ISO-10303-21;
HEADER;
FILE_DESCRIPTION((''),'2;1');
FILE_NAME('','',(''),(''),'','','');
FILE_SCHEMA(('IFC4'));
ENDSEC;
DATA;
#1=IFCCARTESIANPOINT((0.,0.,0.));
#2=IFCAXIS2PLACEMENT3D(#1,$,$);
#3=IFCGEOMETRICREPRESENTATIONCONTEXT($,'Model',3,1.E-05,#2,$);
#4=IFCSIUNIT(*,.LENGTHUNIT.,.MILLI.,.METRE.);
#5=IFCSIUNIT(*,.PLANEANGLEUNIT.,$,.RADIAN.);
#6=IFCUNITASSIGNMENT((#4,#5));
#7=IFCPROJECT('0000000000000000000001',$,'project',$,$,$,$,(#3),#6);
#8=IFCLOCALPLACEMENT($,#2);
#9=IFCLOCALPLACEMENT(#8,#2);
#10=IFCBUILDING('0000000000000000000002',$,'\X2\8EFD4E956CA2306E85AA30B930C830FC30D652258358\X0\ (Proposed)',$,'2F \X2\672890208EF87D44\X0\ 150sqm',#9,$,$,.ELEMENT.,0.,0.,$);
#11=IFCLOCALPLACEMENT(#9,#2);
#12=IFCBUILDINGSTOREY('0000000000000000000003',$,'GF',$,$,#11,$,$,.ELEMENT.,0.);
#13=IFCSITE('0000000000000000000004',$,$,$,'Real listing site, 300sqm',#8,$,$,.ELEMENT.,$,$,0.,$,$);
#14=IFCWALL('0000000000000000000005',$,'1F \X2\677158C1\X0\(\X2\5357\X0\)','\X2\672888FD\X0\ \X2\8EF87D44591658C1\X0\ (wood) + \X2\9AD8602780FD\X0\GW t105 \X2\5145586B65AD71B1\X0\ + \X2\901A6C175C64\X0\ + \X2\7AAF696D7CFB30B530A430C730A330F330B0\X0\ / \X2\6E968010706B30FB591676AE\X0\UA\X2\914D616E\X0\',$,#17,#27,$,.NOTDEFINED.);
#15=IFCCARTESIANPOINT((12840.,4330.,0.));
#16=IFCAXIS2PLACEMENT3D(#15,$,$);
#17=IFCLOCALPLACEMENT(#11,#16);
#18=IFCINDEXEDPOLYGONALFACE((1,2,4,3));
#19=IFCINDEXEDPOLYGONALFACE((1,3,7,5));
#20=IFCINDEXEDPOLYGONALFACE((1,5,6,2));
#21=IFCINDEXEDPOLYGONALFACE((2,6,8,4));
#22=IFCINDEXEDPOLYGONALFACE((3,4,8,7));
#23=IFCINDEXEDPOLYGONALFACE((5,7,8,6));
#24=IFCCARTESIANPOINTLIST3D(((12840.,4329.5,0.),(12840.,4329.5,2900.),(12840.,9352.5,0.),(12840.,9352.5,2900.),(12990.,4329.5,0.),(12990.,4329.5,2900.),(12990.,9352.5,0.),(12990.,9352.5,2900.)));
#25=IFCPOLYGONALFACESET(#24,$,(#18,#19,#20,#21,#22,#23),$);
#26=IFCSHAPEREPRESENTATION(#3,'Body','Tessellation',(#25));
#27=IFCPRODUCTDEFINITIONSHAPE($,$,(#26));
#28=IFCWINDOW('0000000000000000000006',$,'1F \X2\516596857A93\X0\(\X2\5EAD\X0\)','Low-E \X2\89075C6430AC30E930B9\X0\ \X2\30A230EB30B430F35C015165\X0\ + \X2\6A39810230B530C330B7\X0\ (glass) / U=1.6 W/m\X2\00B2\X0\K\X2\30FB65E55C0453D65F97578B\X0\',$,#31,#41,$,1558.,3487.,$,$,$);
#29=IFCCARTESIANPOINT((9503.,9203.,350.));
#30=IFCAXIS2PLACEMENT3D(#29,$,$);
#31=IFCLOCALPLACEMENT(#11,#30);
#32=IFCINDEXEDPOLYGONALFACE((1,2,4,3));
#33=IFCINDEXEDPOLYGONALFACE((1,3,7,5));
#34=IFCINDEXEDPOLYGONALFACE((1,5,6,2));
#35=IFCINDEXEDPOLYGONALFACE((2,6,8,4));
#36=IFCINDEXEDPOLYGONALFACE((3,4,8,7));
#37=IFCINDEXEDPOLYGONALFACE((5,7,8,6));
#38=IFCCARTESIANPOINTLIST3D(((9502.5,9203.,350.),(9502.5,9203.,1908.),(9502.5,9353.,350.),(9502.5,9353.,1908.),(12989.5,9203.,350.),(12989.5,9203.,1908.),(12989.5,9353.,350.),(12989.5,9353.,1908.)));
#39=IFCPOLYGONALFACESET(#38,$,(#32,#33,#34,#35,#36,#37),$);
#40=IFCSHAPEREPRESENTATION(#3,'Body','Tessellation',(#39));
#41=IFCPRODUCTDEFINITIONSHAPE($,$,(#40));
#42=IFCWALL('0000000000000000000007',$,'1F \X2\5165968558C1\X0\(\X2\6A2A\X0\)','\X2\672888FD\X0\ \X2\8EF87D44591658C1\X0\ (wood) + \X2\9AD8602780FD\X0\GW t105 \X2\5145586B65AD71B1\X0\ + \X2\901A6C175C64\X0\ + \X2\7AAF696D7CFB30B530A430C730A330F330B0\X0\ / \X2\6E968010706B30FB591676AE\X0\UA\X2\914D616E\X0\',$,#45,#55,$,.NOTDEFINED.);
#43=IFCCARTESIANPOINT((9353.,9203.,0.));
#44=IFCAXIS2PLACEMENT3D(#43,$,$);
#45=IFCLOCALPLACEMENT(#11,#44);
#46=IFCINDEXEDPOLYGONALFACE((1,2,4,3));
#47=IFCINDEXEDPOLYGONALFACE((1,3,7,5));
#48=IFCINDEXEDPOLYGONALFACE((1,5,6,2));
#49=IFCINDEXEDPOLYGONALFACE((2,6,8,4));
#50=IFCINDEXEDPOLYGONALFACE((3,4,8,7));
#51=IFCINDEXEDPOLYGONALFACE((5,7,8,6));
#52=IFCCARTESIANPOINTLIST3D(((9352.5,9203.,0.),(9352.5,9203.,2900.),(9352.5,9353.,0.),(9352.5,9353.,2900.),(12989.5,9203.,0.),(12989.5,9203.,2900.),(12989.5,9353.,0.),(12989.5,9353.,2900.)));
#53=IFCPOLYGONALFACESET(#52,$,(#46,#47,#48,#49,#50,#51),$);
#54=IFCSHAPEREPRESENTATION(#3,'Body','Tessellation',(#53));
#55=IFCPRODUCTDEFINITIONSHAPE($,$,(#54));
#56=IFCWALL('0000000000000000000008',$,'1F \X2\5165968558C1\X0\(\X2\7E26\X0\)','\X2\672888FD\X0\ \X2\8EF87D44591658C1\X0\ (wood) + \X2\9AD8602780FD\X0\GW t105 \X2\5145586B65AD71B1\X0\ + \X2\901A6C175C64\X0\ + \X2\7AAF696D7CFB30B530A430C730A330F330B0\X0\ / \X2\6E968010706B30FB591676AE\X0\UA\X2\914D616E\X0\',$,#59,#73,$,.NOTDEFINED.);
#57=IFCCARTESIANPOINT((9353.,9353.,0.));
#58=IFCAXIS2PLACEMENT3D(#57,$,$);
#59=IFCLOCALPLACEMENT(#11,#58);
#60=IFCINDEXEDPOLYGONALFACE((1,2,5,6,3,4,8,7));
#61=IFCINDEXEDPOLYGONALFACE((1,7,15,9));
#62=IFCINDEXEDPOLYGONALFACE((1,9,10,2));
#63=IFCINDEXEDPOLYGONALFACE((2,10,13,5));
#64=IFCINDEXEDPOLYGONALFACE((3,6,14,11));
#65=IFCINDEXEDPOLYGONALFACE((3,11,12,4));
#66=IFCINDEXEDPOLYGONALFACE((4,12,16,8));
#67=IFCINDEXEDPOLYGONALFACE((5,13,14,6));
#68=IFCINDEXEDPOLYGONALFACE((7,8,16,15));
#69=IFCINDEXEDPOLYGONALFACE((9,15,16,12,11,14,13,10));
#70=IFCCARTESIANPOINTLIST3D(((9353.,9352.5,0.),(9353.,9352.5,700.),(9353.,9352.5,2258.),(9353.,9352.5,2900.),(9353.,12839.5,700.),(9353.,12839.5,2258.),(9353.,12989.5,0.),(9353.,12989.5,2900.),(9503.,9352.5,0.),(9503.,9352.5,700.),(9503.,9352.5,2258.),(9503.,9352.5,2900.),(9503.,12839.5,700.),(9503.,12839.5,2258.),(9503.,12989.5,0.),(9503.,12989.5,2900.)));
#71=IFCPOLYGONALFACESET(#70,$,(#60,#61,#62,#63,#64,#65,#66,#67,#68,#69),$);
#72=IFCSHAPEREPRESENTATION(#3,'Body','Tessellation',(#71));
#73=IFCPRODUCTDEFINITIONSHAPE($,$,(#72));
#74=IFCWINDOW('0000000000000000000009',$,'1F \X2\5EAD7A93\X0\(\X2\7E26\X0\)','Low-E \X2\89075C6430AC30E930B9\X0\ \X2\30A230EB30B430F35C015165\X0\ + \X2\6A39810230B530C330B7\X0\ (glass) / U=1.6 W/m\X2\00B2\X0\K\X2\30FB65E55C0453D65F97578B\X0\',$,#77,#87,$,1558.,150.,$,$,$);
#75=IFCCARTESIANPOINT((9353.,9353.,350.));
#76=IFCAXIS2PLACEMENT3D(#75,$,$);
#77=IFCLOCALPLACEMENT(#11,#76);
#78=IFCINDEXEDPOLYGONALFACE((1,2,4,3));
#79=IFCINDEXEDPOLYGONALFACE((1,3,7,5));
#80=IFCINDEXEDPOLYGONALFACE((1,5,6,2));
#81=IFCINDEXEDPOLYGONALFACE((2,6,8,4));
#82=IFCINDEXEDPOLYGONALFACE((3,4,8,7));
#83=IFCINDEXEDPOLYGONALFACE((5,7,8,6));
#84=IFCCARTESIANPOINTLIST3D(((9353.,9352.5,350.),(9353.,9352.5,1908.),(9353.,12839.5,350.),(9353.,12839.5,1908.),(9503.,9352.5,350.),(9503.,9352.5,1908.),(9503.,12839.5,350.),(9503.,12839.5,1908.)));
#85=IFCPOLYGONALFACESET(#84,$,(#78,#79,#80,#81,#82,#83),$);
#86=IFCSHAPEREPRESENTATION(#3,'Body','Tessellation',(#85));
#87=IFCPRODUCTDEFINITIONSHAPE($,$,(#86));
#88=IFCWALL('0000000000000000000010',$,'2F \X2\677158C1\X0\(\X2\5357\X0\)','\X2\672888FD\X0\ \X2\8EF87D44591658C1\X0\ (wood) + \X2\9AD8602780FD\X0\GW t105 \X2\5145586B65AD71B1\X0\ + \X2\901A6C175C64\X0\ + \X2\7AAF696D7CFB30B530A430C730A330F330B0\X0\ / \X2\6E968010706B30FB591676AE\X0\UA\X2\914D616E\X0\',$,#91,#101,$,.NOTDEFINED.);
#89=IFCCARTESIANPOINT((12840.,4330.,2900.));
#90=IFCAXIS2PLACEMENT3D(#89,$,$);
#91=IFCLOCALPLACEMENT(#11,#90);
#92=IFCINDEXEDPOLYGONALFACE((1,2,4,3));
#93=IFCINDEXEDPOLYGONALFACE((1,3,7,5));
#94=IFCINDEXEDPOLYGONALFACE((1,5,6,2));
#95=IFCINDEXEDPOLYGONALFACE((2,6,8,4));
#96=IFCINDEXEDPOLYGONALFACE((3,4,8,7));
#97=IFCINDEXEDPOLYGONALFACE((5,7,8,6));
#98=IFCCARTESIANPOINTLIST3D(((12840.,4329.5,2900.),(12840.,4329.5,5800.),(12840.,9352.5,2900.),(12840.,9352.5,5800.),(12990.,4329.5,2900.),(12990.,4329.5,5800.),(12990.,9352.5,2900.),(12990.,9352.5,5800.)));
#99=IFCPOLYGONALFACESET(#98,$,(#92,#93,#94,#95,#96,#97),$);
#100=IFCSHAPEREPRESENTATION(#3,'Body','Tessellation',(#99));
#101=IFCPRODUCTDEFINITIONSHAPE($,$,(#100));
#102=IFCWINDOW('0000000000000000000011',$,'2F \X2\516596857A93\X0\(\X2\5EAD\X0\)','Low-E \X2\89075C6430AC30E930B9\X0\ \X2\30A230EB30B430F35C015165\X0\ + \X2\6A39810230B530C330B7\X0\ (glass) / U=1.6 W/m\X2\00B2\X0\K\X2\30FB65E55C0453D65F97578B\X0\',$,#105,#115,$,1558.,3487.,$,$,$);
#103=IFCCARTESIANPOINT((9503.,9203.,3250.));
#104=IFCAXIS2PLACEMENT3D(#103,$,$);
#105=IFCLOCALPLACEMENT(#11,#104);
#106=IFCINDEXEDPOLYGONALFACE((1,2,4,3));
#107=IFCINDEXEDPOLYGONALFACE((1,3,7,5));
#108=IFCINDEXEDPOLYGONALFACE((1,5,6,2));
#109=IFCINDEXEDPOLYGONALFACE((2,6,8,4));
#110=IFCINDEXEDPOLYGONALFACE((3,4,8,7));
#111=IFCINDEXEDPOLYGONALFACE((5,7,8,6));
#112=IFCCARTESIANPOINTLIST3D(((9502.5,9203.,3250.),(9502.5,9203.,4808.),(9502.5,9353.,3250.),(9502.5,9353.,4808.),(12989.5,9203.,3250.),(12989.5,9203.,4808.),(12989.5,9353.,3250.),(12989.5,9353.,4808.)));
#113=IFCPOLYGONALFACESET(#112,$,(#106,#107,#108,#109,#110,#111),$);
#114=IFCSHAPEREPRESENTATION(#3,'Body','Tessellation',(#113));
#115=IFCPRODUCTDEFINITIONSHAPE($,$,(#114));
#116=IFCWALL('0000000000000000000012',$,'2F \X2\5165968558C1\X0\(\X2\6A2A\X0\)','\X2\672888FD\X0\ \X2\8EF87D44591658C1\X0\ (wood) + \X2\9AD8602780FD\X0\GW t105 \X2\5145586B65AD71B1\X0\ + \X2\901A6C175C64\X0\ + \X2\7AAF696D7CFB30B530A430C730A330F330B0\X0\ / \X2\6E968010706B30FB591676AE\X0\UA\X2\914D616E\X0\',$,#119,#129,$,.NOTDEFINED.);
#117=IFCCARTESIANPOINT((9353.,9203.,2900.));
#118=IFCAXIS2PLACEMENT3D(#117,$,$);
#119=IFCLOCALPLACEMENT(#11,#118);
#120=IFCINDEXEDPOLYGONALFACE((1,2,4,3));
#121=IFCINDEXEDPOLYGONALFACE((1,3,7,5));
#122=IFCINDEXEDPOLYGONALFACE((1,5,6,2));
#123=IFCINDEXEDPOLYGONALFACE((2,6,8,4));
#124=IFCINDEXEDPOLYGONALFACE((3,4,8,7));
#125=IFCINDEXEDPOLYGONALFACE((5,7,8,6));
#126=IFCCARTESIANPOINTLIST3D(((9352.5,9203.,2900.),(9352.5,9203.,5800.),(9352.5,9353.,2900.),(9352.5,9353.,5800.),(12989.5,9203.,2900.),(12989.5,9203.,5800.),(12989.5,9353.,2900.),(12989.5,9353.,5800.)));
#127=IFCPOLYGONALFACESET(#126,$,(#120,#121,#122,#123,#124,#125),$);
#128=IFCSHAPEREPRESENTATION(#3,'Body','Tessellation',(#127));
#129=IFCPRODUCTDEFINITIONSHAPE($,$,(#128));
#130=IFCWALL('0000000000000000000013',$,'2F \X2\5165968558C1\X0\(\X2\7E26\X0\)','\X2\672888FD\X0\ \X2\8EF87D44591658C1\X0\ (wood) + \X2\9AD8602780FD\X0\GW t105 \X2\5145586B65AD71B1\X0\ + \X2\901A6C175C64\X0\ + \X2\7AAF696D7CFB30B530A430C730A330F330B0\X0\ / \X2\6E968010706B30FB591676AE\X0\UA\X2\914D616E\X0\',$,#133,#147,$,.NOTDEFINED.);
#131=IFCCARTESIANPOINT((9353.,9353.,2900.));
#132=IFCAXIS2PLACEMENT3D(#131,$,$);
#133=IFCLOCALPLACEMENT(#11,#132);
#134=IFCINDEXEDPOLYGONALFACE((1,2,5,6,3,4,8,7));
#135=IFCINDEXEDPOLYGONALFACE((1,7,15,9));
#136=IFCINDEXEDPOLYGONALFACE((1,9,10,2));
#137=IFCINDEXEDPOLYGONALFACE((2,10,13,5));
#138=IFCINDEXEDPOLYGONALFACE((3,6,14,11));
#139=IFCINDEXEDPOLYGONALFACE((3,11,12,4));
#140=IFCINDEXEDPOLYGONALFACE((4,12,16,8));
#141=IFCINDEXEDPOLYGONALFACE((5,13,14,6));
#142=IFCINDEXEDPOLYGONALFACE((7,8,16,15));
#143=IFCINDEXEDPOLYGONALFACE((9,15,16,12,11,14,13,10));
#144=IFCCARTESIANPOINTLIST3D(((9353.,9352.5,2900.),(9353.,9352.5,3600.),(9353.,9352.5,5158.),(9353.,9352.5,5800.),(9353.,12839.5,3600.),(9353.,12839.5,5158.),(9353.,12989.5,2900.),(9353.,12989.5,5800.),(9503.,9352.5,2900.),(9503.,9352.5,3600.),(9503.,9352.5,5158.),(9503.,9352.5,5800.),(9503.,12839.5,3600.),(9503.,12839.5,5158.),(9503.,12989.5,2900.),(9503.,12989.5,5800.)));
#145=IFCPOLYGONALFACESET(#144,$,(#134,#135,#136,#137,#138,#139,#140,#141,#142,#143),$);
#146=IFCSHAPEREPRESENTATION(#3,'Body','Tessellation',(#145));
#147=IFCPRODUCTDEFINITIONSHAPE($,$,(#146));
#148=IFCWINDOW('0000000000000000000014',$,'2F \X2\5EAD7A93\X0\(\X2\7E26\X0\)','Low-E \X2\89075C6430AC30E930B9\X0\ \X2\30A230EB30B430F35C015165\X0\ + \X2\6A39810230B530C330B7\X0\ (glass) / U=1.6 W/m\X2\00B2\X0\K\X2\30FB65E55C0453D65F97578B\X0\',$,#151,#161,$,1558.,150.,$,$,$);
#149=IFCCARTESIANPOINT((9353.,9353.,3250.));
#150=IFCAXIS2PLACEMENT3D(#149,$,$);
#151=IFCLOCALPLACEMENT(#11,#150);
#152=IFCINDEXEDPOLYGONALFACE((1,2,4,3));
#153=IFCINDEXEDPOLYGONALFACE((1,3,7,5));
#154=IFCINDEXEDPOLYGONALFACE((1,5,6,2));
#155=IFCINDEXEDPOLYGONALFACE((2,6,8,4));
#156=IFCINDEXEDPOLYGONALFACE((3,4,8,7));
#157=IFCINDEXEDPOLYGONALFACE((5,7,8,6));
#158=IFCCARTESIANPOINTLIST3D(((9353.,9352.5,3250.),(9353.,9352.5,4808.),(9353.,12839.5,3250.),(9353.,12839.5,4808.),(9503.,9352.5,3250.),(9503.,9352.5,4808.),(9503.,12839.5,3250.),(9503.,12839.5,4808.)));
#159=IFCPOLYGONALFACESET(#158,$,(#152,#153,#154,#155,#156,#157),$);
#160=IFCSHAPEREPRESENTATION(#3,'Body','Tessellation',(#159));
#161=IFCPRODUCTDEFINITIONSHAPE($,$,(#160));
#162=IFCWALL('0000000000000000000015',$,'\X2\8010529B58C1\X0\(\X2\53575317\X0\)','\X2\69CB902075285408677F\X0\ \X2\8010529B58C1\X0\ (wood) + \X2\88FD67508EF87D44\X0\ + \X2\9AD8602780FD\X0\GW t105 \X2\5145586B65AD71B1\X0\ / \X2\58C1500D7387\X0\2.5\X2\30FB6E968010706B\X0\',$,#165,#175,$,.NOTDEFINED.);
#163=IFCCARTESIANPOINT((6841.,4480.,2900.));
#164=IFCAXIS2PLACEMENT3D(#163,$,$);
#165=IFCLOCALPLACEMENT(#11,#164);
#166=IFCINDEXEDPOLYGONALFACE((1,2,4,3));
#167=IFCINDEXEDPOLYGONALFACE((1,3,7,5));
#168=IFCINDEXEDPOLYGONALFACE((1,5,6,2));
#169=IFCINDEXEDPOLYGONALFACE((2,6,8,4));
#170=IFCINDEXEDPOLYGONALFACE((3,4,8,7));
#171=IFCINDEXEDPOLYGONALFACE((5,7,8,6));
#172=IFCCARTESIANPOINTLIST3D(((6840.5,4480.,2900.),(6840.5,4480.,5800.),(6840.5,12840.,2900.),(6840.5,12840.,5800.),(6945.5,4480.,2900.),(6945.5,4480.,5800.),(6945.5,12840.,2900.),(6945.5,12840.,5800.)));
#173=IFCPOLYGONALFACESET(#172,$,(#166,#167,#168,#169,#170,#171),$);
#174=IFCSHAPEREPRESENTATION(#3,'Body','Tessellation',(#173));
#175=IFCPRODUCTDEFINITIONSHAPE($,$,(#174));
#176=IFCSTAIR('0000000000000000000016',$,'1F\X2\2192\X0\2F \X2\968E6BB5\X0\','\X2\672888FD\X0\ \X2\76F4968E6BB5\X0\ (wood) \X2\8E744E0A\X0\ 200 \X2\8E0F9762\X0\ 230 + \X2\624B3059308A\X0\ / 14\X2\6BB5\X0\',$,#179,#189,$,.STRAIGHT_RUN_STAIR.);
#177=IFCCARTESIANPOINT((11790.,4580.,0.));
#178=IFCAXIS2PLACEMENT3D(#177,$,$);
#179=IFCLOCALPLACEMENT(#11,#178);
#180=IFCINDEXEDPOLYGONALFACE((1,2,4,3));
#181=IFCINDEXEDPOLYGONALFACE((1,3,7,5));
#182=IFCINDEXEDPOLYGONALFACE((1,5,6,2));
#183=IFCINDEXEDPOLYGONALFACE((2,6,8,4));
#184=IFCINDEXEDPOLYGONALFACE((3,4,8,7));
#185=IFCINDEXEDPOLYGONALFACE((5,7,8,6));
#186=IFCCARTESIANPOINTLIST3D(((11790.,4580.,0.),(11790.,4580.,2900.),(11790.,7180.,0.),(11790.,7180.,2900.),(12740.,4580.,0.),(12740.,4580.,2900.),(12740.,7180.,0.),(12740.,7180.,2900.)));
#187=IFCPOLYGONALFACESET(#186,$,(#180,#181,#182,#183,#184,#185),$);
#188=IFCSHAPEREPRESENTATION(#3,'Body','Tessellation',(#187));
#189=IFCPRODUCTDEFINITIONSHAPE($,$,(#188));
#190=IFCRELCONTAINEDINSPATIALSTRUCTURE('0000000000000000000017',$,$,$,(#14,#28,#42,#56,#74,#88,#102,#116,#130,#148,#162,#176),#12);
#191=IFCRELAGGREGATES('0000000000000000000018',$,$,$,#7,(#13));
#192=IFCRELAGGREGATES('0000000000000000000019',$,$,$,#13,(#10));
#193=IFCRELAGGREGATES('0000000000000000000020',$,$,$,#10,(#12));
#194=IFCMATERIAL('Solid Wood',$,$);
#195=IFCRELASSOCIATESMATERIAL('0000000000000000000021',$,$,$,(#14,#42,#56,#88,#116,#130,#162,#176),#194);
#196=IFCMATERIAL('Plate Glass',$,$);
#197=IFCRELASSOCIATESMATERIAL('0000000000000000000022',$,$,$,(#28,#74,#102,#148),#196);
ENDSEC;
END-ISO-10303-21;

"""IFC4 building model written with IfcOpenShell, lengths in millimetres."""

from ifc_helpers import new_model, si_unit, frame, frame_2d, origin, place, context, project, spatial, rectangle, extrude, material, element, fill, save


model = new_model("IFC4")

# Units and contexts
model_context = context("Model", 3, precision=1e-05, world=origin())
ifc_project = project(units=[si_unit("LENGTHUNIT", "METRE", prefix="MILLI"), si_unit("PLANEANGLEUNIT", "RADIAN")], contexts=[model_context])

# Site, building, storey
site_placement = place(None, origin())
site = spatial("IfcSite", under=ifc_project, at=site_placement, ObjectType="Real listing site, 300sqm", CompositionType="ELEMENT", RefElevation=0.0)
building_placement = place(site_placement, origin())
building = spatial("IfcBuilding", under=site, at=building_placement, Name="軽井沢の薪ストーブ別荘 (Proposed)", ObjectType="2F 木造軸組 150sqm", CompositionType="ELEMENT", ElevationOfRefHeight=0.0, ElevationOfTerrain=0.0)
storey_placement = place(building_placement, origin())
storey = spatial("IfcBuildingStorey", under=building, at=storey_placement, Name="GF", CompositionType="ELEMENT", Elevation=0.0)

# Shared definitions
ifc_material_1 = material(Name="Solid Wood")

# Wall, opening, window
wall_1_placement = place(storey_placement, frame((12840.0, 4330.0, 0.0)))
wall_1 = element("IfcWall", 1, at=wall_1_placement, inside=storey, material=ifc_material_1, Name="1F 東壁(南)", Description="木製 軸組外壁 (wood) + 高性能GW t105 充填断熱 + 通気層 + 窯業系サイディング / 準耐火・外皮UA配慮", PredefinedType="NOTDEFINED", context=model_context, shape_type="SweptSolid", body=[
    extrude(rectangle(XDim=150.0, YDim=5023.0, at=frame_2d((75.0, 2511.0))), frame((12840.0, 4330.0, 0.0)), (0.0, 0.0, 1.0), 2900.0),
])
opening_1_placement = place(storey_placement, frame((9503.0, 9203.0, 350.0)))
opening_1 = element("IfcOpeningElement", 2, at=opening_1_placement, cuts=wall_1, PredefinedType="NOTDEFINED", context=model_context, shape_type="SweptSolid", body=[
    extrude(rectangle(XDim=3487.0, YDim=150.0, at=frame_2d((1743.0, 75.0))), frame((9503.0, 9203.0, 350.0)), (0.0, 0.0, 1.0), 1558.0),
])
ifc_material_2 = material(Name="Plate Glass")
window_1_placement = place(storey_placement, frame((9503.0, 9203.0, 350.0)))
window_1 = element("IfcWindow", 3, at=window_1_placement, inside=storey, material=ifc_material_2, Name="1F 入隅窓(庭)", Description="Low-E 複層ガラス アルゴン封入 + 樹脂サッシ (glass) / U=1.6 W/m²K・日射取得型", OverallHeight=1558.0, OverallWidth=3487.0, context=model_context, shape_type="SweptSolid", body=[
    extrude(rectangle(XDim=3487.0, YDim=150.0, at=frame_2d((1743.0, 75.0))), frame((9503.0, 9203.0, 350.0)), (0.0, 0.0, 1.0), 1558.0),
])
fill(opening_1, window_1)

# Wall
wall_2_placement = place(storey_placement, frame((9353.0, 9203.0, 0.0)))
element("IfcWall", 4, at=wall_2_placement, inside=storey, material=ifc_material_1, Name="1F 入隅壁(横)", Description="木製 軸組外壁 (wood) + 高性能GW t105 充填断熱 + 通気層 + 窯業系サイディング / 準耐火・外皮UA配慮", PredefinedType="NOTDEFINED", context=model_context, shape_type="SweptSolid", body=[
    extrude(rectangle(XDim=3637.0, YDim=150.0, at=frame_2d((1818.0, 75.0))), frame((9353.0, 9203.0, 0.0)), (0.0, 0.0, 1.0), 2900.0),
])

# Wall, opening, window
wall_3_placement = place(storey_placement, frame((9353.0, 9353.0, 0.0)))
wall_3 = element("IfcWall", 5, at=wall_3_placement, inside=storey, material=ifc_material_1, Name="1F 入隅壁(縦)", Description="木製 軸組外壁 (wood) + 高性能GW t105 充填断熱 + 通気層 + 窯業系サイディング / 準耐火・外皮UA配慮", PredefinedType="NOTDEFINED", context=model_context, shape_type="SweptSolid", body=[
    extrude(rectangle(XDim=150.0, YDim=3637.0, at=frame_2d((75.0, 1818.0))), frame((9353.0, 9353.0, 0.0)), (0.0, 0.0, 1.0), 2900.0),
])
opening_2_placement = place(storey_placement, frame((9353.0, 9353.0, 350.0)))
opening_2 = element("IfcOpeningElement", 6, at=opening_2_placement, cuts=wall_3, PredefinedType="NOTDEFINED", context=model_context, shape_type="SweptSolid", body=[
    extrude(rectangle(XDim=150.0, YDim=3487.0, at=frame_2d((75.0, 1743.0))), frame((9353.0, 9353.0, 350.0)), (0.0, 0.0, 1.0), 1558.0),
])
window_2_placement = place(storey_placement, frame((9353.0, 9353.0, 350.0)))
window_2 = element("IfcWindow", 7, at=window_2_placement, inside=storey, material=ifc_material_2, Name="1F 庭窓(縦)", Description="Low-E 複層ガラス アルゴン封入 + 樹脂サッシ (glass) / U=1.6 W/m²K・日射取得型", OverallHeight=1558.0, OverallWidth=150.0, context=model_context, shape_type="SweptSolid", body=[
    extrude(rectangle(XDim=150.0, YDim=3487.0, at=frame_2d((75.0, 1743.0))), frame((9353.0, 9353.0, 350.0)), (0.0, 0.0, 1.0), 1558.0),
])
fill(opening_2, window_2)

# Wall, opening, window
wall_4_placement = place(storey_placement, frame((12840.0, 4330.0, 2900.0)))
wall_4 = element("IfcWall", 8, at=wall_4_placement, inside=storey, material=ifc_material_1, Name="2F 東壁(南)", Description="木製 軸組外壁 (wood) + 高性能GW t105 充填断熱 + 通気層 + 窯業系サイディング / 準耐火・外皮UA配慮", PredefinedType="NOTDEFINED", context=model_context, shape_type="SweptSolid", body=[
    extrude(rectangle(XDim=150.0, YDim=5023.0, at=frame_2d((75.0, 2511.0))), frame((12840.0, 4330.0, 2900.0)), (0.0, 0.0, 1.0), 2900.0),
])
opening_3_placement = place(storey_placement, frame((9503.0, 9203.0, 3250.0)))
opening_3 = element("IfcOpeningElement", 9, at=opening_3_placement, cuts=wall_4, PredefinedType="NOTDEFINED", context=model_context, shape_type="SweptSolid", body=[
    extrude(rectangle(XDim=3487.0, YDim=150.0, at=frame_2d((1743.0, 75.0))), frame((9503.0, 9203.0, 3250.0)), (0.0, 0.0, 1.0), 1558.0),
])
window_3_placement = place(storey_placement, frame((9503.0, 9203.0, 3250.0)))
window_3 = element("IfcWindow", 10, at=window_3_placement, inside=storey, material=ifc_material_2, Name="2F 入隅窓(庭)", Description="Low-E 複層ガラス アルゴン封入 + 樹脂サッシ (glass) / U=1.6 W/m²K・日射取得型", OverallHeight=1558.0, OverallWidth=3487.0, context=model_context, shape_type="SweptSolid", body=[
    extrude(rectangle(XDim=3487.0, YDim=150.0, at=frame_2d((1743.0, 75.0))), frame((9503.0, 9203.0, 3250.0)), (0.0, 0.0, 1.0), 1558.0),
])
fill(opening_3, window_3)

# Wall
wall_5_placement = place(storey_placement, frame((9353.0, 9203.0, 2900.0)))
element("IfcWall", 11, at=wall_5_placement, inside=storey, material=ifc_material_1, Name="2F 入隅壁(横)", Description="木製 軸組外壁 (wood) + 高性能GW t105 充填断熱 + 通気層 + 窯業系サイディング / 準耐火・外皮UA配慮", PredefinedType="NOTDEFINED", context=model_context, shape_type="SweptSolid", body=[
    extrude(rectangle(XDim=3637.0, YDim=150.0, at=frame_2d((1818.0, 75.0))), frame((9353.0, 9203.0, 2900.0)), (0.0, 0.0, 1.0), 2900.0),
])

# Wall, opening, window
wall_6_placement = place(storey_placement, frame((9353.0, 9353.0, 2900.0)))
wall_6 = element("IfcWall", 12, at=wall_6_placement, inside=storey, material=ifc_material_1, Name="2F 入隅壁(縦)", Description="木製 軸組外壁 (wood) + 高性能GW t105 充填断熱 + 通気層 + 窯業系サイディング / 準耐火・外皮UA配慮", PredefinedType="NOTDEFINED", context=model_context, shape_type="SweptSolid", body=[
    extrude(rectangle(XDim=150.0, YDim=3637.0, at=frame_2d((75.0, 1818.0))), frame((9353.0, 9353.0, 2900.0)), (0.0, 0.0, 1.0), 2900.0),
])
opening_4_placement = place(storey_placement, frame((9353.0, 9353.0, 3250.0)))
opening_4 = element("IfcOpeningElement", 13, at=opening_4_placement, cuts=wall_6, PredefinedType="NOTDEFINED", context=model_context, shape_type="SweptSolid", body=[
    extrude(rectangle(XDim=150.0, YDim=3487.0, at=frame_2d((75.0, 1743.0))), frame((9353.0, 9353.0, 3250.0)), (0.0, 0.0, 1.0), 1558.0),
])
window_4_placement = place(storey_placement, frame((9353.0, 9353.0, 3250.0)))
window_4 = element("IfcWindow", 14, at=window_4_placement, inside=storey, material=ifc_material_2, Name="2F 庭窓(縦)", Description="Low-E 複層ガラス アルゴン封入 + 樹脂サッシ (glass) / U=1.6 W/m²K・日射取得型", OverallHeight=1558.0, OverallWidth=150.0, context=model_context, shape_type="SweptSolid", body=[
    extrude(rectangle(XDim=150.0, YDim=3487.0, at=frame_2d((75.0, 1743.0))), frame((9353.0, 9353.0, 3250.0)), (0.0, 0.0, 1.0), 1558.0),
])
fill(opening_4, window_4)

# Wall
wall_7_placement = place(storey_placement, frame((6841.0, 4480.0, 2900.0)))
element("IfcWall", 15, at=wall_7_placement, inside=storey, material=ifc_material_1, Name="耐力壁(南北)", Description="構造用合板 耐力壁 (wood) + 製材軸組 + 高性能GW t105 充填断熱 / 壁倍率2.5・準耐火", PredefinedType="NOTDEFINED", context=model_context, shape_type="SweptSolid", body=[
    extrude(rectangle(XDim=105.0, YDim=8360.0, at=frame_2d((52.0, 4180.0))), frame((6841.0, 4480.0, 2900.0)), (0.0, 0.0, 1.0), 2900.0),
])

# Stair
stair_placement = place(storey_placement, frame((11790.0, 4580.0, 0.0)))
element("IfcStair", 16, at=stair_placement, inside=storey, material=ifc_material_1, Name="1F→2F 階段", Description="木製 直階段 (wood) 蹴上 200 踏面 230 + 手すり / 14段", PredefinedType="STRAIGHT_RUN_STAIR", context=model_context, shape_type="SweptSolid", body=[
    extrude(rectangle(XDim=950.0, YDim=2600.0, at=frame_2d((475.0, 1300.0))), frame((11790.0, 4580.0, 0.0)), (0.0, 0.0, 1.0), 2900.0),
])

save(model, "model.ifc")
